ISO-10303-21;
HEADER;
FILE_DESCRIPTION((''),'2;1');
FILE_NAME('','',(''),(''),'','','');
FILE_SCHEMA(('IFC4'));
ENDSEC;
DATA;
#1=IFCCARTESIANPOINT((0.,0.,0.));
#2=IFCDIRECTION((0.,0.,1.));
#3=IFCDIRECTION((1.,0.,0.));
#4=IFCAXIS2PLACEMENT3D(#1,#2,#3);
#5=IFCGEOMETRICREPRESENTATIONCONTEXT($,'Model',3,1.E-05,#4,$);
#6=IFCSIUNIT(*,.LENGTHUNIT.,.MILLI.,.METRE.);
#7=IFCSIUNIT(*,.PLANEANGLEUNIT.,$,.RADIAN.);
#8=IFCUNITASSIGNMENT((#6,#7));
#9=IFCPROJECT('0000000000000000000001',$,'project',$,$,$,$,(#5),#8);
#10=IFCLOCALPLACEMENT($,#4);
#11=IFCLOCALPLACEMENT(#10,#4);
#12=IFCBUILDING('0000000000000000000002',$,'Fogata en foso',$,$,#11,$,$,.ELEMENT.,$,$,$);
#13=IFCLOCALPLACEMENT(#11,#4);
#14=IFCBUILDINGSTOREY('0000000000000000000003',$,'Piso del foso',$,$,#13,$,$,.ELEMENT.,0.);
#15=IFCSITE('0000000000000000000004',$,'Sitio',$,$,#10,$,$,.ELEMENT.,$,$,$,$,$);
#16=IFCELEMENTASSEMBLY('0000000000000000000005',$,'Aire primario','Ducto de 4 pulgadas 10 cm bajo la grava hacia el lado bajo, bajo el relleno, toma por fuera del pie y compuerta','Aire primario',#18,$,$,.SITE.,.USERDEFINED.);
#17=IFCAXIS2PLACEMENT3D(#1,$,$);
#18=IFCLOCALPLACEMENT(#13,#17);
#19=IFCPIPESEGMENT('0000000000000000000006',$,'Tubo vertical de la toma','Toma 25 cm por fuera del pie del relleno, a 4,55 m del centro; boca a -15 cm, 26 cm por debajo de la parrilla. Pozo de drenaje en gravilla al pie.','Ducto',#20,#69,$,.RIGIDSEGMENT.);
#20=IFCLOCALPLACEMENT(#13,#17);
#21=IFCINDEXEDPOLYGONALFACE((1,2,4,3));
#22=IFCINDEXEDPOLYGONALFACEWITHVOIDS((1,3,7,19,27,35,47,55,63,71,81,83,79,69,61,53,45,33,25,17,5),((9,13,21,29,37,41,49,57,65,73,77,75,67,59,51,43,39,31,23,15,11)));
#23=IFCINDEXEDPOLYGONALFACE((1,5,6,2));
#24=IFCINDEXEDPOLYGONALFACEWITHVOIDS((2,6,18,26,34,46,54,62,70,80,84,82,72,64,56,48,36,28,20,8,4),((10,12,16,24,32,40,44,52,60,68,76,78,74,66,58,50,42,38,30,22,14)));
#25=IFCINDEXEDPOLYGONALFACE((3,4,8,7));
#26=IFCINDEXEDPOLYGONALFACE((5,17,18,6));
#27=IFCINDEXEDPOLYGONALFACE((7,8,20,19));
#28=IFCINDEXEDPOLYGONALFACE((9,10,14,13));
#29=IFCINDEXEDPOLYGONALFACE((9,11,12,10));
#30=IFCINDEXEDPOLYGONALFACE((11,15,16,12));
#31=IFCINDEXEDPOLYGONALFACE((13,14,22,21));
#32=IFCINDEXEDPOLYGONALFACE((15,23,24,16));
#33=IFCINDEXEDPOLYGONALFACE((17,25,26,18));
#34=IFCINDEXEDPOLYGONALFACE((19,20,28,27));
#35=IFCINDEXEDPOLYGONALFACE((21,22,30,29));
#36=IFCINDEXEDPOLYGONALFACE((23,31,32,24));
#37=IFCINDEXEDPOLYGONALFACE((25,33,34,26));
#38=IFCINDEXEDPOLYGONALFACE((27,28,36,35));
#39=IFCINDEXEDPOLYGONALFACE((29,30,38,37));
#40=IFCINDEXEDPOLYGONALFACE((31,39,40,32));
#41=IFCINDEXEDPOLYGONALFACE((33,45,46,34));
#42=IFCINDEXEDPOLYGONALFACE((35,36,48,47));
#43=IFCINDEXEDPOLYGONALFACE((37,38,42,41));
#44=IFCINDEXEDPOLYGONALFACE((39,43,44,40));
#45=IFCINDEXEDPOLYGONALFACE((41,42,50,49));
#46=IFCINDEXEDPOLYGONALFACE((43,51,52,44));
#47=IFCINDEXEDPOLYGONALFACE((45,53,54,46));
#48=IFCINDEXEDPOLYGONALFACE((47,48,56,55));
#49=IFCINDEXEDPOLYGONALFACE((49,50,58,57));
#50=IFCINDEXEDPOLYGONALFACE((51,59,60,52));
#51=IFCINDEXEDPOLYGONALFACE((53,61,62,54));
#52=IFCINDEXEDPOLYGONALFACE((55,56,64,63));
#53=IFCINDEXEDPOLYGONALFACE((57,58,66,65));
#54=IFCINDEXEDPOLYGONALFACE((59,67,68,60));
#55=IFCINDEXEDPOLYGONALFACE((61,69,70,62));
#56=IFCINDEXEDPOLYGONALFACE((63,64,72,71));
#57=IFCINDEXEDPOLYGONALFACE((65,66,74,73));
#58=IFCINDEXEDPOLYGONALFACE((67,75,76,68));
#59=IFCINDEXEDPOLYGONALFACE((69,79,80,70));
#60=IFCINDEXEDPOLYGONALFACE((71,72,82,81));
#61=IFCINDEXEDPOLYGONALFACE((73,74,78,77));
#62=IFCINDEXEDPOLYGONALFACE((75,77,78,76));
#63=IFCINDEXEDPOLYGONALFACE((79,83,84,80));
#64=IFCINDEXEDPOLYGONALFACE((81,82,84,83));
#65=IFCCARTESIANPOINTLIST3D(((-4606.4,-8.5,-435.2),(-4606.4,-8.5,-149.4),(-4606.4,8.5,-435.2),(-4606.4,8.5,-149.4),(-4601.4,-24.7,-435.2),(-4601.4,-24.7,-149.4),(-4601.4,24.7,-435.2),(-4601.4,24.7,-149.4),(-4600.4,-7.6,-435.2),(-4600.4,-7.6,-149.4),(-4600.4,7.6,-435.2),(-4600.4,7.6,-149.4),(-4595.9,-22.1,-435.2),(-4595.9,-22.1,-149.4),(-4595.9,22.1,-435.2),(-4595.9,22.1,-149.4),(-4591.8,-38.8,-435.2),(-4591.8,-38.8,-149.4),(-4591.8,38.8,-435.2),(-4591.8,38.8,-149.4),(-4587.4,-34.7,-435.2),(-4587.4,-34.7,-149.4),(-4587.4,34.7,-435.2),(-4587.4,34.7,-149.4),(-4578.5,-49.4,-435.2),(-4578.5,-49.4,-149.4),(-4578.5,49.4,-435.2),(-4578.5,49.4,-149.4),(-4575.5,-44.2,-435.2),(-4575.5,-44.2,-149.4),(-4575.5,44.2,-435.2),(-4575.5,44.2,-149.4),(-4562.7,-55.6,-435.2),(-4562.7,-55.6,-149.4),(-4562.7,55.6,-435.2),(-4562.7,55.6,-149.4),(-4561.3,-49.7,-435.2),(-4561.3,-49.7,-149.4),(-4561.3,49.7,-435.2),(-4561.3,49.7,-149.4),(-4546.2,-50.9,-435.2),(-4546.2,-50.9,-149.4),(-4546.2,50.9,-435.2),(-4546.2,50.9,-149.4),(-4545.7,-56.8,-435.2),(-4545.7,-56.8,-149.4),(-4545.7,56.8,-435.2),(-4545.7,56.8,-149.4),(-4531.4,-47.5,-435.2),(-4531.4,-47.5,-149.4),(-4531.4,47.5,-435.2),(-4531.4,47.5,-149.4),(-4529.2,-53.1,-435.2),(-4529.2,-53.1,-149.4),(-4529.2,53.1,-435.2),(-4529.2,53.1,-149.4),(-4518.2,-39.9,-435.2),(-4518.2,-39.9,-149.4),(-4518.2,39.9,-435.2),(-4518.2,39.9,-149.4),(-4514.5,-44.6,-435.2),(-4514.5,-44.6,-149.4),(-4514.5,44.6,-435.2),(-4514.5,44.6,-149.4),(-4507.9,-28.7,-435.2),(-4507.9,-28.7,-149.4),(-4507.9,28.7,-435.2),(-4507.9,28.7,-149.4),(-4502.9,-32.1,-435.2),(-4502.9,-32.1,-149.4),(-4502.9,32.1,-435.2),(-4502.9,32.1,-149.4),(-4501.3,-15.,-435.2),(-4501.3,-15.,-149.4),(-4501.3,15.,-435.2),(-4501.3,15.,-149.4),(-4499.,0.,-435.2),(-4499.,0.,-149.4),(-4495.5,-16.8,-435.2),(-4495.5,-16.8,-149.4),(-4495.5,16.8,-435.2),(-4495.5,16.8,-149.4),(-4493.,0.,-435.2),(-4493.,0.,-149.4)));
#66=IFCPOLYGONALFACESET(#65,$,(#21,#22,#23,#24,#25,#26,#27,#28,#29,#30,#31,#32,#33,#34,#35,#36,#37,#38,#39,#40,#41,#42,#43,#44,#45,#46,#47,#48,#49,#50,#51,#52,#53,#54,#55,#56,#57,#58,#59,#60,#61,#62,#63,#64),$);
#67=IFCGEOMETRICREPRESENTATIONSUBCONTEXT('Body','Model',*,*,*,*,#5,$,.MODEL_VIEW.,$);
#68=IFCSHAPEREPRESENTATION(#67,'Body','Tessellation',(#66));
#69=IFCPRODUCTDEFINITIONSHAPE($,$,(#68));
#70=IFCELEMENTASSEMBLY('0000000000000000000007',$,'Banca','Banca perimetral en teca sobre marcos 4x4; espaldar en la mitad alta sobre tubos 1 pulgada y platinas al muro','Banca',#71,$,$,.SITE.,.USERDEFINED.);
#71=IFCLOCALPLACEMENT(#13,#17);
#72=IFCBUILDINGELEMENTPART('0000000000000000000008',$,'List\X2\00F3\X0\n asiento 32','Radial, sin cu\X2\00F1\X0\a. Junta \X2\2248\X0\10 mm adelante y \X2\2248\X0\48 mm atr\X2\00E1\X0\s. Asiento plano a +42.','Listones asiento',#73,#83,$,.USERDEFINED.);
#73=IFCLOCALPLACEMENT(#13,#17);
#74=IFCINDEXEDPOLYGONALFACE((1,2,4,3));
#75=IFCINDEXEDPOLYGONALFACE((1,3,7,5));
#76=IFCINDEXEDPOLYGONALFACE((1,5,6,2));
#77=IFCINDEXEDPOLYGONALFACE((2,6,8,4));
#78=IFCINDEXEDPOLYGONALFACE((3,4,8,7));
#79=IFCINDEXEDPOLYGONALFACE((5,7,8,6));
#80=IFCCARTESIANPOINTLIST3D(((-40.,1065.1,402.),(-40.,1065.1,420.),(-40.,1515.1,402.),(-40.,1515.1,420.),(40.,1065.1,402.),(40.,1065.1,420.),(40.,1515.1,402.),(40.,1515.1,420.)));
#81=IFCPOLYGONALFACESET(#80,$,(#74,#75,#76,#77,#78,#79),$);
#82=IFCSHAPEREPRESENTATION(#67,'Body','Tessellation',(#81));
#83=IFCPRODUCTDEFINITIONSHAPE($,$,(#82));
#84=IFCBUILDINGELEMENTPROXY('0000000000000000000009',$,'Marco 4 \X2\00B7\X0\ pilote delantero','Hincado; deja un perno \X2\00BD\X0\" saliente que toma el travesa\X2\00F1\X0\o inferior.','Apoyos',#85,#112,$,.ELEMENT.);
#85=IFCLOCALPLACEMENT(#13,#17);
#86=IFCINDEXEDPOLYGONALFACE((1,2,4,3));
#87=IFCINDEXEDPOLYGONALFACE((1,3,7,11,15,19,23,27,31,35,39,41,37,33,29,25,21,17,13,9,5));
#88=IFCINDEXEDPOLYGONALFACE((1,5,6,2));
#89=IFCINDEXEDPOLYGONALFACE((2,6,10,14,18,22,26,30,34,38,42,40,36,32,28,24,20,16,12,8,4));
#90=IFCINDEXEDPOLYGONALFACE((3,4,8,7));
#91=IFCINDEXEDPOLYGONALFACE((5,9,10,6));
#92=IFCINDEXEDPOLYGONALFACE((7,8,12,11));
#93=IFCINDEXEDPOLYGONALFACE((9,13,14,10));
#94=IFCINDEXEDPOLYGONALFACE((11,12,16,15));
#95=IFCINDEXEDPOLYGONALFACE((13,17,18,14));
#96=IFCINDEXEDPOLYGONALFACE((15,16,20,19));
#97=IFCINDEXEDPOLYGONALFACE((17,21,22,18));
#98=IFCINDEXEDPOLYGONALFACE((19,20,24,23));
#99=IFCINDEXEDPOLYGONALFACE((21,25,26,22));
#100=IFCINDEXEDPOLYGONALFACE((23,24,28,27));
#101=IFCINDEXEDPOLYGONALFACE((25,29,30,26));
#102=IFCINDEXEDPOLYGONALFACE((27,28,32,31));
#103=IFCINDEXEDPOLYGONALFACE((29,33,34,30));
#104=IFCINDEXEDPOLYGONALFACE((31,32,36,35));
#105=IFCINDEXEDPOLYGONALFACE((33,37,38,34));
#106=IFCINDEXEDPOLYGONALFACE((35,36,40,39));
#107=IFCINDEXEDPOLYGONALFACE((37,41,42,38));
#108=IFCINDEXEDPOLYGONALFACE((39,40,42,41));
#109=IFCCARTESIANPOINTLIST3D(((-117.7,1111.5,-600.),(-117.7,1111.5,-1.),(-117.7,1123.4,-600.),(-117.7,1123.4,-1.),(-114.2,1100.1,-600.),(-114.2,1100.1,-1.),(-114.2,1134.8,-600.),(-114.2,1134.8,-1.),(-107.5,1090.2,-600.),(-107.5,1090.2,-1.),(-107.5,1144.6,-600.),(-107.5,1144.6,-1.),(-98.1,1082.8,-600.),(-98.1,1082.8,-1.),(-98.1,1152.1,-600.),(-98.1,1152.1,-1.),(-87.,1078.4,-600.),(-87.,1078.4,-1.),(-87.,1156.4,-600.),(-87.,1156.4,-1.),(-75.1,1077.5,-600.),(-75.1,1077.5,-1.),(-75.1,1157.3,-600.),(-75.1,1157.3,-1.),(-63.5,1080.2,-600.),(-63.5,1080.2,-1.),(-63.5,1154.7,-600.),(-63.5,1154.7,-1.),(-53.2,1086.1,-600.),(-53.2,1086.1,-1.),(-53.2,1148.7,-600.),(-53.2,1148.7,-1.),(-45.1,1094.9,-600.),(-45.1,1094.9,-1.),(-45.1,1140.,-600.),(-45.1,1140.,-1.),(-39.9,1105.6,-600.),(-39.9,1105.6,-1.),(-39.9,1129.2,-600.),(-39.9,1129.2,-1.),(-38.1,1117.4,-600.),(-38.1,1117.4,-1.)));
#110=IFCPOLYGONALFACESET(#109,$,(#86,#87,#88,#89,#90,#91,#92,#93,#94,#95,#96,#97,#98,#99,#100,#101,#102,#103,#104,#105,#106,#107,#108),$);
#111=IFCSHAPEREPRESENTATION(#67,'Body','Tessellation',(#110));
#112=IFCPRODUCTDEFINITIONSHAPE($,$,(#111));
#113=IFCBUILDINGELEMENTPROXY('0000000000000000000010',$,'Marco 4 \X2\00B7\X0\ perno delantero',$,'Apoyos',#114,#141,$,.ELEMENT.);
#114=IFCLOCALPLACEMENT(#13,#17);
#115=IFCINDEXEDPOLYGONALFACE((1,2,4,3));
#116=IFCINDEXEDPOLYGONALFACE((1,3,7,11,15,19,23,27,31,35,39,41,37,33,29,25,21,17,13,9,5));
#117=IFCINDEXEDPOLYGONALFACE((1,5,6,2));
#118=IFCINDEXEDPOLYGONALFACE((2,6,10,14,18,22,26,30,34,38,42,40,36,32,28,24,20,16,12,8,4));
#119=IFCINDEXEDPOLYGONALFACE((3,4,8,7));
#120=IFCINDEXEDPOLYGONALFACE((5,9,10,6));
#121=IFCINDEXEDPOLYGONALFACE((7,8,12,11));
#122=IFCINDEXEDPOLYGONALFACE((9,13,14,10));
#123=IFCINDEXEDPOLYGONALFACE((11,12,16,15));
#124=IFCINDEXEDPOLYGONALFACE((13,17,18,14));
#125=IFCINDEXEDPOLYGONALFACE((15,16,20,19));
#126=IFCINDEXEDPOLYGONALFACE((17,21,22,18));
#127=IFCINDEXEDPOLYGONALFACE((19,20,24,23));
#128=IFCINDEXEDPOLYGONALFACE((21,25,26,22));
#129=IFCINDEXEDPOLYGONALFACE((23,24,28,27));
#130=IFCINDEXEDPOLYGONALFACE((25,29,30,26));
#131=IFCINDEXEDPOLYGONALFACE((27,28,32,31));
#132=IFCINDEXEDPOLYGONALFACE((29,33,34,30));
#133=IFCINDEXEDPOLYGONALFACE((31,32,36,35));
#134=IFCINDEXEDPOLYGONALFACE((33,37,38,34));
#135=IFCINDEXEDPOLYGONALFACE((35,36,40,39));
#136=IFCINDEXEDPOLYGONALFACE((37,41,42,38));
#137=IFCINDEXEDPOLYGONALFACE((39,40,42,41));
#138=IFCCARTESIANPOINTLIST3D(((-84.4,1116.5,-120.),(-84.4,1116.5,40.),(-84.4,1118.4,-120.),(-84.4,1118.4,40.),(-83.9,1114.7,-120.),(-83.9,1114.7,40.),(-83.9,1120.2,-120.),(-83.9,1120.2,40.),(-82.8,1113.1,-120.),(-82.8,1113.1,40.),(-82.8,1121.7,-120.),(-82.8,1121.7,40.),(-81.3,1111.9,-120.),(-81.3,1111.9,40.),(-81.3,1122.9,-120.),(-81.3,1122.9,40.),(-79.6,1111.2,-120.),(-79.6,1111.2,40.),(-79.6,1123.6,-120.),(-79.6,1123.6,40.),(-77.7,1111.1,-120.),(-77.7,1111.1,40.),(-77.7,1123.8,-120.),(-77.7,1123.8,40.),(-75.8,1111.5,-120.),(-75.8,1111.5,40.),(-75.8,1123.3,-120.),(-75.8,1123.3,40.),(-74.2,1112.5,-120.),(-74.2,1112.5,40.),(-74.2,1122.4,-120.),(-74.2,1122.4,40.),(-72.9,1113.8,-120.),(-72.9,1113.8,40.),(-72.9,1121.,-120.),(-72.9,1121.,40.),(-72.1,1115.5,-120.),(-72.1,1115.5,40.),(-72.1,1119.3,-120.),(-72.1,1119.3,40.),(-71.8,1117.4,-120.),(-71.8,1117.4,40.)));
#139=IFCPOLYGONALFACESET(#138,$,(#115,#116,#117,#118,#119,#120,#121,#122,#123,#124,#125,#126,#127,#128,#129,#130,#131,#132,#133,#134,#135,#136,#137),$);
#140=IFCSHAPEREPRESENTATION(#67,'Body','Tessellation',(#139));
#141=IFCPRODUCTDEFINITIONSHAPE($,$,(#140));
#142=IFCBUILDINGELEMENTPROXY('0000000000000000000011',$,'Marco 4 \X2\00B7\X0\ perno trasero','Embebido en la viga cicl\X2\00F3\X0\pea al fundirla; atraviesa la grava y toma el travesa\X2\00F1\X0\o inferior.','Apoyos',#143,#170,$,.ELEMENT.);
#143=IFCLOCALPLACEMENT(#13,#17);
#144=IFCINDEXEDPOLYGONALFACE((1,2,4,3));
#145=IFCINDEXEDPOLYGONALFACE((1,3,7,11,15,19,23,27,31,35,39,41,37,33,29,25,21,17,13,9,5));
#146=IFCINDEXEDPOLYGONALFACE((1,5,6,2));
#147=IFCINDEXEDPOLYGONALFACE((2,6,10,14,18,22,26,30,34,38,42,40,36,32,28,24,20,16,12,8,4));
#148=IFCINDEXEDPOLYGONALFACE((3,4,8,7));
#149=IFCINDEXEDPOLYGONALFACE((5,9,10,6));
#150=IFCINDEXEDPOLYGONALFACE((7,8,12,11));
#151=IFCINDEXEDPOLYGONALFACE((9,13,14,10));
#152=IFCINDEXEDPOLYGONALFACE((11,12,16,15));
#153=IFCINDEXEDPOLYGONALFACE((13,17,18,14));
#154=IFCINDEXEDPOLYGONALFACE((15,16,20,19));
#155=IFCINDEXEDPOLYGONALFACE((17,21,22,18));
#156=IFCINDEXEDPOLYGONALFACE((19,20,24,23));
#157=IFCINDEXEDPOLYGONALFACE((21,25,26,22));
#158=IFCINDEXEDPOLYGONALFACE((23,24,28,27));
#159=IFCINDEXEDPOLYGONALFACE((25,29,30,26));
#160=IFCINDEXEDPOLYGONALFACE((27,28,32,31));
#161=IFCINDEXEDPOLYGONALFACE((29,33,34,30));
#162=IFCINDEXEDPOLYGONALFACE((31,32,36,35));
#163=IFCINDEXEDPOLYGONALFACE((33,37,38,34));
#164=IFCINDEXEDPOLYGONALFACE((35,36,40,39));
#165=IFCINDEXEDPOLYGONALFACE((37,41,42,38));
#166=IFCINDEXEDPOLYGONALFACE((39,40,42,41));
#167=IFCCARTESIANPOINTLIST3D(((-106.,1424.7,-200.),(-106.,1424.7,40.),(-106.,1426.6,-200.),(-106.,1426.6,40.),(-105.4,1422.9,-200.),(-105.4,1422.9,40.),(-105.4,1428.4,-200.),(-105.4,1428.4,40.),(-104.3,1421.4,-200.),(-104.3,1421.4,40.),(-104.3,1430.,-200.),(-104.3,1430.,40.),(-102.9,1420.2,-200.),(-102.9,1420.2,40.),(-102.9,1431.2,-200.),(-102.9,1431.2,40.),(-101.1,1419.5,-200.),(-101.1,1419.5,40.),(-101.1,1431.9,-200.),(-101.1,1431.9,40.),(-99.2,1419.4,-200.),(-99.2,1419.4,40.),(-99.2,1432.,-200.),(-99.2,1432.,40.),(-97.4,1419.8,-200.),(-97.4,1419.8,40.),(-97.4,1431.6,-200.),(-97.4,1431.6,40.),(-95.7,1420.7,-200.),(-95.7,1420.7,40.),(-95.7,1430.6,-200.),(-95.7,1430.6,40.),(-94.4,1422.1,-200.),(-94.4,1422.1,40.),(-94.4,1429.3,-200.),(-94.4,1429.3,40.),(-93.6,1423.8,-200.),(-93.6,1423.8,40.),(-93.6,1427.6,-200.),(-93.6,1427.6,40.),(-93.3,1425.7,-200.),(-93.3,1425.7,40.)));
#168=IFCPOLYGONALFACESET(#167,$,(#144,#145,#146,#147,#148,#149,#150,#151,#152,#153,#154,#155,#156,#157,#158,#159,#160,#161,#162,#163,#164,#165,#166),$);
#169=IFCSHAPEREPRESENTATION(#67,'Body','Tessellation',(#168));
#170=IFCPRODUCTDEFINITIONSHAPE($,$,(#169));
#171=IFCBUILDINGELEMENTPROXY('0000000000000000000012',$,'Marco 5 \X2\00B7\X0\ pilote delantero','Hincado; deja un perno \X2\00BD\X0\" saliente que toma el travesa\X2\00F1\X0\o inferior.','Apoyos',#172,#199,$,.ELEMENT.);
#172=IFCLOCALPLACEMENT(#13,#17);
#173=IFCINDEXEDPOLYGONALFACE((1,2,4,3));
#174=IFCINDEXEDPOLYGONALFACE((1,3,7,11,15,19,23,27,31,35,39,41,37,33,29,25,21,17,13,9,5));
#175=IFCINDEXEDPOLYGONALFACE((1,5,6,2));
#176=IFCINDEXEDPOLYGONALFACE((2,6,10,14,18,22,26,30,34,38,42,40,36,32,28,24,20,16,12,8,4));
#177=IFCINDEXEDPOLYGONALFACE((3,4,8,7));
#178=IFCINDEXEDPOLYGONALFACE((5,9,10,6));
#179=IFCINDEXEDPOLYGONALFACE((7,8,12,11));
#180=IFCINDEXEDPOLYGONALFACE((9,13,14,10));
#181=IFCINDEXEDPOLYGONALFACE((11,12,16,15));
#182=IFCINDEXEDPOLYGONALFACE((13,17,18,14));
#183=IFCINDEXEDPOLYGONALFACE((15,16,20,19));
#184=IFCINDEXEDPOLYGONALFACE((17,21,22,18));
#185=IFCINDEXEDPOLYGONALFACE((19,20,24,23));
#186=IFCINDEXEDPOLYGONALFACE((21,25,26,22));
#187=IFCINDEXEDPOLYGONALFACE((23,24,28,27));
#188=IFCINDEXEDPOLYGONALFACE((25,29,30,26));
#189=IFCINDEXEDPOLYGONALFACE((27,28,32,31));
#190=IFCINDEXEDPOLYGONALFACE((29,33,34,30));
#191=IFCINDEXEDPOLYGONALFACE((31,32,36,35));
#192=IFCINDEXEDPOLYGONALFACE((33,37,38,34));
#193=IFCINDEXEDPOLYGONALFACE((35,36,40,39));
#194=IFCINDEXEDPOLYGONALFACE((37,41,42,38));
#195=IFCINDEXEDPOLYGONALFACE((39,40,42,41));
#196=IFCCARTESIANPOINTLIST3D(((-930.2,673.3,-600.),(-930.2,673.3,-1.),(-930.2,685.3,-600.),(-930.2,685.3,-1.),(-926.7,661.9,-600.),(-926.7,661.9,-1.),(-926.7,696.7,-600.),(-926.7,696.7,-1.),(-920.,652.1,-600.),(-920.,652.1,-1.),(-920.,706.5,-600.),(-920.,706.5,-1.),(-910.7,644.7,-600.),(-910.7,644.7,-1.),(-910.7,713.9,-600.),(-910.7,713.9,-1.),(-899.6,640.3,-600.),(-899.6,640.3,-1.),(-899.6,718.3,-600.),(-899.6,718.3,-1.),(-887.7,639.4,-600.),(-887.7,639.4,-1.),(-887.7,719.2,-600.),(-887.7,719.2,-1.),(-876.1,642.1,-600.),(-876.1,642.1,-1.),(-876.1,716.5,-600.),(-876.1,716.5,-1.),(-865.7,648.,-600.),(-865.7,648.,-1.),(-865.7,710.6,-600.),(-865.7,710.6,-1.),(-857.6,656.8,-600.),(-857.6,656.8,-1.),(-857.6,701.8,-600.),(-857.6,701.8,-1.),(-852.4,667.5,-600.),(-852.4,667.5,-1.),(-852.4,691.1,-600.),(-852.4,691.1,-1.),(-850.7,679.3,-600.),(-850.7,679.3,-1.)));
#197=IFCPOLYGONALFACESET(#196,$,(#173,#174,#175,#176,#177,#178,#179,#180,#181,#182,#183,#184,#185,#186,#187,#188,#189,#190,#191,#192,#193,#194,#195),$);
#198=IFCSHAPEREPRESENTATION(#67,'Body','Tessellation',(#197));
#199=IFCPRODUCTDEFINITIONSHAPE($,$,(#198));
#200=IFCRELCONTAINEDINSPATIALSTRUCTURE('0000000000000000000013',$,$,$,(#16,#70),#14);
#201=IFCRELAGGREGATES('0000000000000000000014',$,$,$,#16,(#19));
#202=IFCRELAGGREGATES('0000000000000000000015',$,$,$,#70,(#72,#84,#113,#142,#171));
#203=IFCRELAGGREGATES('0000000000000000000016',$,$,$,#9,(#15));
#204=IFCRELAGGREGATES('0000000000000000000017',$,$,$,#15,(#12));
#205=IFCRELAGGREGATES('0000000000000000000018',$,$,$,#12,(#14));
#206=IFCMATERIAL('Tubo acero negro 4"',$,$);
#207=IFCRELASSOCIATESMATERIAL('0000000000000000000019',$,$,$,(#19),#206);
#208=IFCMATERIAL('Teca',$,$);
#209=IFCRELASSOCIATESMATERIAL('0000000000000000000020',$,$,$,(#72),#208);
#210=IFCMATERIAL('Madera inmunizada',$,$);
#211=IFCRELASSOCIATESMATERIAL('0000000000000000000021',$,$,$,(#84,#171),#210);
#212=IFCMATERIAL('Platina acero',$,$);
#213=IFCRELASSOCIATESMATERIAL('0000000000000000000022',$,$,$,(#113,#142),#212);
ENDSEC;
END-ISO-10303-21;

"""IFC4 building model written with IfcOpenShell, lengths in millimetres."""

from ifc_helpers import new_model, si_unit, frame, origin_with_axes, origin_2d, place, context, subcontext, project, spatial, polyline, circle, hollow_circle, outline, extrude, material, element, aggregate, save


model = new_model("IFC4")

# Units and contexts
model_context = context("Model", 3, precision=1e-05, world=origin_with_axes())
body_context = subcontext(model_context, "Body", "Model", "MODEL_VIEW")
ifc_project = project(units=[si_unit("LENGTHUNIT", "METRE", prefix="MILLI"), si_unit("PLANEANGLEUNIT", "RADIAN")], contexts=[model_context])

# Site, building, storey
site_placement = place(None, origin_with_axes())
site = spatial("IfcSite", under=ifc_project, at=site_placement, Name="Sitio", CompositionType="ELEMENT")
building_placement = place(site_placement, origin_with_axes())
building = spatial("IfcBuilding", under=site, at=building_placement, Name="Fogata en foso", CompositionType="ELEMENT")
storey_placement = place(building_placement, origin_with_axes())
storey = spatial("IfcBuildingStorey", under=building, at=storey_placement, Name="Piso del foso", CompositionType="ELEMENT", Elevation=0.0)

# Element assembly, pipe segment
assembly_1_placement = place(storey_placement, origin_with_axes())
assembly_1 = element("IfcElementAssembly", 1, at=assembly_1_placement, inside=storey, Name="Aire primario", Description="Ducto de 4 pulgadas 10 cm bajo la grava hacia el lado bajo, bajo el relleno, toma por fuera del pie y compuerta", ObjectType="Aire primario", AssemblyPlace="SITE", PredefinedType="USERDEFINED")
ifc_material_1 = material(Name="Tubo acero negro 4\"")
pipe_segment_1_placement = place(storey_placement, frame((-4550.0, 0.0, -435.1), z_axis=(0.0, 0.0, 1.0), x_axis=(1.0, 0.0, 0.0)))
pipe_segment_1 = element("IfcPipeSegment", 2, at=pipe_segment_1_placement, material=ifc_material_1, Name="Tubo vertical de la toma", Description="Toma 25 cm por fuera del pie del relleno, a 4,55 m del centro; boca a -15 cm, 26 cm por debajo de la parrilla. Pozo de drenaje en gravilla al pie.", ObjectType="Ducto", PredefinedType="RIGIDSEGMENT", context=body_context, shape_type="SweptSolid", body=[
    extrude(hollow_circle(Radius=57.0, WallThickness=6.0, at=origin_2d()), origin_with_axes(), (0.0, 0.0, 1.0), 285.7),
])
aggregate(assembly_1, [pipe_segment_1])

# Element assembly, building element part, building element proxies
assembly_2_placement = place(storey_placement, origin_with_axes())
assembly_2 = element("IfcElementAssembly", 3, at=assembly_2_placement, inside=storey, Name="Banca", Description="Banca perimetral en teca sobre marcos 4x4; espaldar en la mitad alta sobre tubos 1 pulgada y platinas al muro", ObjectType="Banca", AssemblyPlace="SITE", PredefinedType="USERDEFINED")
ifc_material_2 = material(Name="Teca")
building_element_part_1_placement = place(storey_placement, frame((-40.0, 0.0, 0.0), z_axis=(1.0, 0.0, 0.0), x_axis=(0.0, 1.0, 0.0)))
building_element_part_1 = element("IfcBuildingElementPart", 4, at=building_element_part_1_placement, material=ifc_material_2, Name="Listón asiento 32", Description="Radial, sin cuña. Junta ≈10 mm adelante y ≈48 mm atrás. Asiento plano a +42.", ObjectType="Listones asiento", PredefinedType="USERDEFINED", context=body_context, shape_type="SweptSolid", body=[
    extrude(outline(polyline([(1065.1, 402.0), (1515.1, 402.0), (1515.1, 420.0), (1065.1, 420.0), (1065.1, 402.0)])), origin_with_axes(), (0.0, 0.0, 1.0), 80.0),
])
ifc_material_3 = material(Name="Madera inmunizada")
proxy_1_placement = place(storey_placement, frame((-78.1, 1117.4, -600.0), z_axis=(0.0, 0.0, 1.0), x_axis=(1.0, 0.0, 0.0)))
proxy_1 = element("IfcBuildingElementProxy", 5, at=proxy_1_placement, material=ifc_material_3, Name="Marco 4 · pilote delantero", Description="Hincado; deja un perno ½\" saliente que toma el travesaño inferior.", ObjectType="Apoyos", PredefinedType="ELEMENT", context=body_context, shape_type="SweptSolid", body=[
    extrude(circle(Radius=40.0, at=origin_2d()), origin_with_axes(), (0.0, 0.0, 1.0), 599.0),
])
ifc_material_4 = material(Name="Platina acero")
proxy_2_placement = place(storey_placement, frame((-78.1, 1117.4, -120.0), z_axis=(0.0, 0.0, 1.0), x_axis=(1.0, 0.0, 0.0)))
proxy_2 = element("IfcBuildingElementProxy", 6, at=proxy_2_placement, material=ifc_material_4, Name="Marco 4 · perno delantero", ObjectType="Apoyos", PredefinedType="ELEMENT", context=body_context, shape_type="SweptSolid", body=[
    extrude(circle(Radius=6.3, at=origin_2d()), origin_with_axes(), (0.0, 0.0, 1.0), 160.0),
])
proxy_3_placement = place(storey_placement, frame((-99.7, 1425.7, -200.0), z_axis=(0.0, 0.0, 1.0), x_axis=(1.0, 0.0, 0.0)))
proxy_3 = element("IfcBuildingElementProxy", 7, at=proxy_3_placement, material=ifc_material_4, Name="Marco 4 · perno trasero", Description="Embebido en la viga ciclópea al fundirla; atraviesa la grava y toma el travesaño inferior.", ObjectType="Apoyos", PredefinedType="ELEMENT", context=body_context, shape_type="SweptSolid", body=[
    extrude(circle(Radius=6.3, at=origin_2d()), origin_with_axes(), (0.0, 0.0, 1.0), 240.0),
])
proxy_4_placement = place(storey_placement, frame((-890.7, 679.3, -600.0), z_axis=(0.0, 0.0, 1.0), x_axis=(1.0, 0.0, 0.0)))
proxy_4 = element("IfcBuildingElementProxy", 8, at=proxy_4_placement, material=ifc_material_3, Name="Marco 5 · pilote delantero", Description="Hincado; deja un perno ½\" saliente que toma el travesaño inferior.", ObjectType="Apoyos", PredefinedType="ELEMENT", context=body_context, shape_type="SweptSolid", body=[
    extrude(circle(Radius=40.0, at=origin_2d()), origin_with_axes(), (0.0, 0.0, 1.0), 599.0),
])
aggregate(assembly_2, [building_element_part_1, proxy_1, proxy_2, proxy_3, proxy_4])

save(model, "model.ifc")
